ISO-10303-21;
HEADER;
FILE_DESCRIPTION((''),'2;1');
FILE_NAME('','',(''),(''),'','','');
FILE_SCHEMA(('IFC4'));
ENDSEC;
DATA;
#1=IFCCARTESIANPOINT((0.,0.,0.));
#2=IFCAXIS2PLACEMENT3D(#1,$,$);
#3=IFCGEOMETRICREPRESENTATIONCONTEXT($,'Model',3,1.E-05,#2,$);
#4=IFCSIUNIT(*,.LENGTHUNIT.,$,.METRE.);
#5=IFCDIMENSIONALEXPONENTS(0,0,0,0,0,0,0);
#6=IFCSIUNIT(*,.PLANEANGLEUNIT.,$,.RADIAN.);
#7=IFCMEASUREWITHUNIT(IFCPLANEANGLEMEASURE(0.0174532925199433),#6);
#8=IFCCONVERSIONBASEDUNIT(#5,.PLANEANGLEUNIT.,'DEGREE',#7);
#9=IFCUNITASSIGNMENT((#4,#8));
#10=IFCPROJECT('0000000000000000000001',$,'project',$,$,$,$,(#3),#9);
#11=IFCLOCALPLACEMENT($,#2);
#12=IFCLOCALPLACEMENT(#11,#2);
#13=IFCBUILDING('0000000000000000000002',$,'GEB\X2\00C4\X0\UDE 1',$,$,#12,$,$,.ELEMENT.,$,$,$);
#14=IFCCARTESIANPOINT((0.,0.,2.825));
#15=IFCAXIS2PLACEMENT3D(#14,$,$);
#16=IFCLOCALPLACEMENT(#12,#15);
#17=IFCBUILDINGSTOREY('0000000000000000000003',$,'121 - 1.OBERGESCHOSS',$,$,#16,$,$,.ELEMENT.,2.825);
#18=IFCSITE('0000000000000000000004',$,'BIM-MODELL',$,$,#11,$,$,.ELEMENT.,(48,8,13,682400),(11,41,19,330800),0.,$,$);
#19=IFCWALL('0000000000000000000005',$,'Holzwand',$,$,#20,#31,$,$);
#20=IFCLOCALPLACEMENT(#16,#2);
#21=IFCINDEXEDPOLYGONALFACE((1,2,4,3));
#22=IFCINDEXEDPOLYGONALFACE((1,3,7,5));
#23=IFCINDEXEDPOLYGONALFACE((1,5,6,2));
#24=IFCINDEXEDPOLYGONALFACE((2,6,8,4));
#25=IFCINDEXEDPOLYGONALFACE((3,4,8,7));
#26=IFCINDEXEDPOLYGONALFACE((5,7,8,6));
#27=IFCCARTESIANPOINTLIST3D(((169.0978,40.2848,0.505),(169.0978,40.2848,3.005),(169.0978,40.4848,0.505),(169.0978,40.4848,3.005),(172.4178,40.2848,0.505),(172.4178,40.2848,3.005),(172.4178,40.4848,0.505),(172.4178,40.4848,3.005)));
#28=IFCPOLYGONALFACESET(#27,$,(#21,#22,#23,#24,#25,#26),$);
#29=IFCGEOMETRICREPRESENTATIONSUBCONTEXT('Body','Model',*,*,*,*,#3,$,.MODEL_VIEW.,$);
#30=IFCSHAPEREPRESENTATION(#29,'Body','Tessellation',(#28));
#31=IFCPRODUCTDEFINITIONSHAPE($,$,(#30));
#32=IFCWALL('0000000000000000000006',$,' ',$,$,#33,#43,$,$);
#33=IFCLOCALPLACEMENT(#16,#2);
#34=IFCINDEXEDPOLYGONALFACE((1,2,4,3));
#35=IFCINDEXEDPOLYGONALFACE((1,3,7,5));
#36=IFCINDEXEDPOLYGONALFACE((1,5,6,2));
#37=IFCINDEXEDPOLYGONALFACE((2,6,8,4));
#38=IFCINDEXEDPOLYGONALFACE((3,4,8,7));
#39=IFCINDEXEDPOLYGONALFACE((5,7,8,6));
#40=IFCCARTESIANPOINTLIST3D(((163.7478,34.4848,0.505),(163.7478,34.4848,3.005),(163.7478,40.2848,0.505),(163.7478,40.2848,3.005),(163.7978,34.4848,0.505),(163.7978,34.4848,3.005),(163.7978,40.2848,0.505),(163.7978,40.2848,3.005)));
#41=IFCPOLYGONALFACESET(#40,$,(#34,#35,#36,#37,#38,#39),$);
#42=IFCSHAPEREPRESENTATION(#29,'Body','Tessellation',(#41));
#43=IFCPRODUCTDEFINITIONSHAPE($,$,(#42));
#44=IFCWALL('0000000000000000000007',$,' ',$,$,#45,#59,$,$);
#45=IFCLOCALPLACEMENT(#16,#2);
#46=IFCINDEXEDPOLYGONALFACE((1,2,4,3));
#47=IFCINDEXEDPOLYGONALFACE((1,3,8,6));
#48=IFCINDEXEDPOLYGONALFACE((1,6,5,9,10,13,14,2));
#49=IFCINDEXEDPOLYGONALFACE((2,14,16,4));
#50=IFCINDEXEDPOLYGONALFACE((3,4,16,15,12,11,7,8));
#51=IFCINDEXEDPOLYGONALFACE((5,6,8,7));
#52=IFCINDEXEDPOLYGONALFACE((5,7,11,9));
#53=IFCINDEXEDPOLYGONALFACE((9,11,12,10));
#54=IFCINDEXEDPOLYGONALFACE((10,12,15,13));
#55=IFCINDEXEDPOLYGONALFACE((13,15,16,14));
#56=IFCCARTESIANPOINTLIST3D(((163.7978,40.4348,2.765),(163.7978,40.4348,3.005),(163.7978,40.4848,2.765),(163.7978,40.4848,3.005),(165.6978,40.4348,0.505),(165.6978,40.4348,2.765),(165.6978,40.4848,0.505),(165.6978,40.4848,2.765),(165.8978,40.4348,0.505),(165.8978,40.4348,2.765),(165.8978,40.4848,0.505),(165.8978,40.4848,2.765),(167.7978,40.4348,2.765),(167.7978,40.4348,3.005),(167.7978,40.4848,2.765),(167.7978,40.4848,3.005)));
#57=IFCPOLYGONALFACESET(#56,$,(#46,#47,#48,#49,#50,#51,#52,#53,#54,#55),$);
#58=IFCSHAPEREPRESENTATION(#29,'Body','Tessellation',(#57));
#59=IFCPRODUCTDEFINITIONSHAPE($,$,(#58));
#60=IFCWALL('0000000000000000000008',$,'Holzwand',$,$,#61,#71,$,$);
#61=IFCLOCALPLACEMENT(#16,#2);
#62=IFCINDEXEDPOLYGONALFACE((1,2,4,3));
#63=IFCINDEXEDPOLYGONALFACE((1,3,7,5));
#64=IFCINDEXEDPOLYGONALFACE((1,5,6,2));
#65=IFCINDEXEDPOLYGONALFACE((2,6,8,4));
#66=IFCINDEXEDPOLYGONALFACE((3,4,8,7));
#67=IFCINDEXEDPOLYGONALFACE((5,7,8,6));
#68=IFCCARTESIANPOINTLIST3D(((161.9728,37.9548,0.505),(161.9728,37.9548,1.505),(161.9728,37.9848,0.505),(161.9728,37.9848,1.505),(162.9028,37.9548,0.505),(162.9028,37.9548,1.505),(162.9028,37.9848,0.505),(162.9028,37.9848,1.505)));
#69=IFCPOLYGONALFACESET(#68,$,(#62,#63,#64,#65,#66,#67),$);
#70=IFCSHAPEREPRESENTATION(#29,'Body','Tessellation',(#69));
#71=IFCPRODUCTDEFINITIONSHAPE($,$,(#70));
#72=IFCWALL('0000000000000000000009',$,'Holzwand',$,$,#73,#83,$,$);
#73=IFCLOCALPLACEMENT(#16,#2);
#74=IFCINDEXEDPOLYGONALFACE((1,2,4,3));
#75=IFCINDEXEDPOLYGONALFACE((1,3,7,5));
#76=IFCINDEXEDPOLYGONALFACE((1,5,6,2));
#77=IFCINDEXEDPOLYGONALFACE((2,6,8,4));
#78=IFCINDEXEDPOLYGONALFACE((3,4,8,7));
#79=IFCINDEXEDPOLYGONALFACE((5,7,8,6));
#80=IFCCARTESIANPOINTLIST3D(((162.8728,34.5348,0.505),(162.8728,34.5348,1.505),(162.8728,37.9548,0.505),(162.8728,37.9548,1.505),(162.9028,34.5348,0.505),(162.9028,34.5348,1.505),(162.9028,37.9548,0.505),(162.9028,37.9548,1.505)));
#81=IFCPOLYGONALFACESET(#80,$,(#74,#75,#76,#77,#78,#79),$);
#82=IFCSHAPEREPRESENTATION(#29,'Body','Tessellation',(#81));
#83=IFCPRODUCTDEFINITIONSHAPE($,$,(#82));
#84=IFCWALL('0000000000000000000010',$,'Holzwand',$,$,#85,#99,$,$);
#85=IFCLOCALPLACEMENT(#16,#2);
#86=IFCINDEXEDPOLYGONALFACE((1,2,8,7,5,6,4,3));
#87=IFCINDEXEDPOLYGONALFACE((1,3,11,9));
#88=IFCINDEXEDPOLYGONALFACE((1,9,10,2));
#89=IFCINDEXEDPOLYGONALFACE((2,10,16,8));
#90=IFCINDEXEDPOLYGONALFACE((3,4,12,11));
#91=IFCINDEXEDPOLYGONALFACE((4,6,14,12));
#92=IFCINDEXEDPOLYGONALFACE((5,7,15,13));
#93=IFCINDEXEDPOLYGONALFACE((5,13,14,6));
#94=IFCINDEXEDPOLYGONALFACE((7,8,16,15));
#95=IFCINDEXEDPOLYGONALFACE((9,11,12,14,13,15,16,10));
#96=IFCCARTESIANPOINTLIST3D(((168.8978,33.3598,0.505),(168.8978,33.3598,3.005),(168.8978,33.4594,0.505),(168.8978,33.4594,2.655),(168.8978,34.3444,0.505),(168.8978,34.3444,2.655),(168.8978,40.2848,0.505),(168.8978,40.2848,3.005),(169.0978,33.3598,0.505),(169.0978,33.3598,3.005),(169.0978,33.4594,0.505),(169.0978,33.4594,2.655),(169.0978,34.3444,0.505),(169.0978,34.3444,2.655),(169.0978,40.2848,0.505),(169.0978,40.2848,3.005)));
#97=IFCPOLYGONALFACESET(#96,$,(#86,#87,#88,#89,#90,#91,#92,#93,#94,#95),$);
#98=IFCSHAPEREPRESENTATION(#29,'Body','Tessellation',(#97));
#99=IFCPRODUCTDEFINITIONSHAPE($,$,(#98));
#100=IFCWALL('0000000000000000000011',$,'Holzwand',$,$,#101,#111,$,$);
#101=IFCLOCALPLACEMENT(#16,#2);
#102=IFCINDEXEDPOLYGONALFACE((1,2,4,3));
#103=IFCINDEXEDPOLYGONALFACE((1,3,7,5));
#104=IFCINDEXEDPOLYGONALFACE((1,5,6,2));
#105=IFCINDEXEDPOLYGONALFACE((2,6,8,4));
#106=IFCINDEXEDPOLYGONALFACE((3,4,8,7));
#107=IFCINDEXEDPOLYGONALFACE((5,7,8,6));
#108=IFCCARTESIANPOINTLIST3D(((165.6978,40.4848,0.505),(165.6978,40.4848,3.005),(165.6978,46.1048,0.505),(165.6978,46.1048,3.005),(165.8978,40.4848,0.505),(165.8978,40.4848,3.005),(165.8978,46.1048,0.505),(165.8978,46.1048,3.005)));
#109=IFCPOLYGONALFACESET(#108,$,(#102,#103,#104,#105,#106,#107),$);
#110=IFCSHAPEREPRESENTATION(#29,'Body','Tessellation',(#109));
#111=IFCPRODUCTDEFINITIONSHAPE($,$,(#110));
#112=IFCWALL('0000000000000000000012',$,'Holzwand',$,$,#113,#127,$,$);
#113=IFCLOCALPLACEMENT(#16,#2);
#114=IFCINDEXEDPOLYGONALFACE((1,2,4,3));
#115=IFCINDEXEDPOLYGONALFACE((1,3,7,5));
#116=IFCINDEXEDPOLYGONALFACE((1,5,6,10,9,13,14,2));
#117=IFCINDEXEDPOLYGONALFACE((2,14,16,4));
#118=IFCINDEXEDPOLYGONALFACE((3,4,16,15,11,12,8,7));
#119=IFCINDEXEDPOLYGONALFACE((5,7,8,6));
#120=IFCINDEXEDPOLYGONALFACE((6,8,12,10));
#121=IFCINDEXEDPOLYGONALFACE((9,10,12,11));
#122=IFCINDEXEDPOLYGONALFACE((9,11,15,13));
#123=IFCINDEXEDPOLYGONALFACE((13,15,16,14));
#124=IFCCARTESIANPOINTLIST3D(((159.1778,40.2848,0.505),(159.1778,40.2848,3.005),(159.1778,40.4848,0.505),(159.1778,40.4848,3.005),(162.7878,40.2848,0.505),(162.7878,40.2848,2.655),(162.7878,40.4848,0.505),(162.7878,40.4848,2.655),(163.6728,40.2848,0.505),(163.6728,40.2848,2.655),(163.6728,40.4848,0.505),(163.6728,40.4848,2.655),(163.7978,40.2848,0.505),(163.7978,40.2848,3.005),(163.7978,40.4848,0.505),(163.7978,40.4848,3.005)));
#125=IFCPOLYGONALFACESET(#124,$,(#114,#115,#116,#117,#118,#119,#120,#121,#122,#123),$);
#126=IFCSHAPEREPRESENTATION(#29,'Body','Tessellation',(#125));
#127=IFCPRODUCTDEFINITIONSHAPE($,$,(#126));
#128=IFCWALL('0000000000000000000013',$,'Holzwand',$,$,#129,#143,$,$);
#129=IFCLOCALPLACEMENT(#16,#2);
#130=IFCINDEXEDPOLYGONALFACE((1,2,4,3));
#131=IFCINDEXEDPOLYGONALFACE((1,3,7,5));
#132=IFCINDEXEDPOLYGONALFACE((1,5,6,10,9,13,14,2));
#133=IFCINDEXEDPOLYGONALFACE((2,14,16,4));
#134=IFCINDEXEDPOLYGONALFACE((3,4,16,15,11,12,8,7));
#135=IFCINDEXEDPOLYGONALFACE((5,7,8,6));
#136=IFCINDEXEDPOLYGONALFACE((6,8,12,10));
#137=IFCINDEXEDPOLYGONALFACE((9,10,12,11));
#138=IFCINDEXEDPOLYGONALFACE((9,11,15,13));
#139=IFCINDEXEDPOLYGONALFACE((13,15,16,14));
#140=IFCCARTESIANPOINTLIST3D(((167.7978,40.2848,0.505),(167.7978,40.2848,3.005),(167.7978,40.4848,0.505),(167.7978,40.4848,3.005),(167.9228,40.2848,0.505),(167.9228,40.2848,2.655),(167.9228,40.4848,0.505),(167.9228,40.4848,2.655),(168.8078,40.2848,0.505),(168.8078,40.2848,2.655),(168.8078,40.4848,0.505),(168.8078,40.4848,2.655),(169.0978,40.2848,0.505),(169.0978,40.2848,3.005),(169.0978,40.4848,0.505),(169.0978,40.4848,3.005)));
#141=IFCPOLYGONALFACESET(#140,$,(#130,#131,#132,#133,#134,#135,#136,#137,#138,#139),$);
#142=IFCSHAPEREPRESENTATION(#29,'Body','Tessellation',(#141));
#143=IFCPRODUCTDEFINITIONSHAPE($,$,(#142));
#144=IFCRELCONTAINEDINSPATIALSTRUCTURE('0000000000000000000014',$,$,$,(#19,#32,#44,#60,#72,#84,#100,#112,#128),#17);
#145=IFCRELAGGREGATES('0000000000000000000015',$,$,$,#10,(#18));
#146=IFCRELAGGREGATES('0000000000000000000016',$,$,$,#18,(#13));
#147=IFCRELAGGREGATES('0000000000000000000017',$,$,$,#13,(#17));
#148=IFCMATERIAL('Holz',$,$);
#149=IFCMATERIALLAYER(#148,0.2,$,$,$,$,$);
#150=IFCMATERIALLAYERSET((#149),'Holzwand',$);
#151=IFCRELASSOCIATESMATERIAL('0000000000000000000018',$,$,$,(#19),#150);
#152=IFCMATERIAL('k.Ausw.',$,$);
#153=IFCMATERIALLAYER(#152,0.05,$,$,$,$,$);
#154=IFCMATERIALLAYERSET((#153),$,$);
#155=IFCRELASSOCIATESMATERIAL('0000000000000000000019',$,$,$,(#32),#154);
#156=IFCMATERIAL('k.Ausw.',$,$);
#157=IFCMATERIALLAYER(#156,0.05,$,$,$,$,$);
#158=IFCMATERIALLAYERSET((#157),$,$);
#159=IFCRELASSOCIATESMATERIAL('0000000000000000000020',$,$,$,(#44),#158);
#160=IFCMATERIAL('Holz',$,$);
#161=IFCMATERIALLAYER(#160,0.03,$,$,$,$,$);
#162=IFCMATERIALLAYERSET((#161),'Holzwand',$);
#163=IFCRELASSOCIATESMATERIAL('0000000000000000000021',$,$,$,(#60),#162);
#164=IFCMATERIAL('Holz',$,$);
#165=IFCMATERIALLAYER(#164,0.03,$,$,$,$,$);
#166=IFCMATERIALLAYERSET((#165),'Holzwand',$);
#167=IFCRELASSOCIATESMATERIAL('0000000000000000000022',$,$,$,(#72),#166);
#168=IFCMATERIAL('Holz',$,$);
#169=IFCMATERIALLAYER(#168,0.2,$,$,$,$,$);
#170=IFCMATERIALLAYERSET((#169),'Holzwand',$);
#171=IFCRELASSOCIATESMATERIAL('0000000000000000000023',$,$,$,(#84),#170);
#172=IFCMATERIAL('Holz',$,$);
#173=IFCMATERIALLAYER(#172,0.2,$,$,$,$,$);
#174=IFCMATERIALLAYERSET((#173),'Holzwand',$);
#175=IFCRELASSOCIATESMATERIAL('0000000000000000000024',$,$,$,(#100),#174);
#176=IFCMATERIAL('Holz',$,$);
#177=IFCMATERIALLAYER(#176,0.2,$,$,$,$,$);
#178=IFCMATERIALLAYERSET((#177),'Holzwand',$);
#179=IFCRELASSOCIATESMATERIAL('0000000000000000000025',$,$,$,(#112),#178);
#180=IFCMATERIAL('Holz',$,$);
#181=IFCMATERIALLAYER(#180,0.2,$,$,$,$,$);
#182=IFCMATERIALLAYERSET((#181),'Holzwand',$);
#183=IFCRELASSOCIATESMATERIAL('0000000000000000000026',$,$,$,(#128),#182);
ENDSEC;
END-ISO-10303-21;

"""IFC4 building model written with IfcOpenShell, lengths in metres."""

from ifc_helpers import new_model, entity, si_unit, converted_unit, frame, frame_2d, origin, origin_with_axes, place, context, subcontext, project, spatial, polyline, rectangle, outline, extrude, material, layer, layer_set, layer_usage, element, save


model = new_model("IFC4")

# Units and contexts
model_context = context("Model", 3, precision=1e-05, world=origin())
body_context = subcontext(model_context, "Body", "Model", "MODEL_VIEW")
ifc_project = project(units=[si_unit("LENGTHUNIT", "METRE"), converted_unit("PLANEANGLEUNIT", "DEGREE", entity("IfcPlaneAngleMeasure", 0.0174532925199433), si_unit("PLANEANGLEUNIT", "RADIAN"), dimensions=[0, 0, 0, 0, 0, 0, 0])], contexts=[model_context])

# Site, building, storey
site_placement = place(None, origin())
site = spatial("IfcSite", under=ifc_project, at=site_placement, Name="BIM-MODELL", CompositionType="ELEMENT", RefLatitude=(48, 8, 13, 682400), RefLongitude=(11, 41, 19, 330800), RefElevation=0.0)
building_placement = place(site_placement, origin())
building = spatial("IfcBuilding", under=site, at=building_placement, Name="GEBÄUDE 1", CompositionType="ELEMENT")
storey_placement = place(building_placement, frame((0.0, 0.0, 2.825)))
storey = spatial("IfcBuildingStorey", under=building, at=storey_placement, Name="121 - 1.OBERGESCHOSS", CompositionType="ELEMENT", Elevation=2.825)

# Walls
ifc_material_1 = material(Name="Holz")
ifc_layer_1 = layer(ifc_material_1, 0.2)
ifc_layer_set_1 = layer_set([ifc_layer_1], Name="Holzwand")
ifc_layer_usage_1 = layer_usage(ifc_layer_set_1, "AXIS2", "POSITIVE", -0.1)
wall_1_placement = place(storey_placement, frame((172.4178, 40.4848, 0.505), z_axis=(0.0, 0.0, 1.0), x_axis=(-1.0, 0.0, 0.0)))
element("IfcWall", 1, at=wall_1_placement, inside=storey, material=ifc_layer_usage_1, Name="Holzwand", context=body_context, shape_type="SweptSolid", body=[
    extrude(rectangle(XDim=3.32, YDim=0.2, at=frame_2d((1.66, 0.1), x_axis=(1.0, 0.0))), origin_with_axes(), (0.0, 0.0, 1.0), 2.5),
])
ifc_material_2 = material(Name="k.Ausw.")
ifc_layer_2 = layer(ifc_material_2, 0.05)
ifc_layer_set_2 = layer_set([ifc_layer_2])
ifc_layer_usage_2 = layer_usage(ifc_layer_set_2, "AXIS2", "POSITIVE", 0.0)
wall_2_placement = place(storey_placement, frame((163.7478, 40.2848, 0.505), z_axis=(0.0, 0.0, 1.0), x_axis=(0.0, -1.0, 0.0)))
element("IfcWall", 2, at=wall_2_placement, inside=storey, material=ifc_layer_usage_2, Name=" ", context=body_context, shape_type="SweptSolid", body=[
    extrude(rectangle(XDim=5.8, YDim=0.05, at=frame_2d((2.9, 0.025), x_axis=(1.0, 0.0))), origin_with_axes(), (0.0, 0.0, 1.0), 2.5),
])

# Wall, openings
ifc_material_3 = material(Name="k.Ausw.")
ifc_layer_3 = layer(ifc_material_3, 0.05)
ifc_layer_set_3 = layer_set([ifc_layer_3])
ifc_layer_usage_3 = layer_usage(ifc_layer_set_3, "AXIS2", "POSITIVE", 0.0)
wall_3_placement = place(storey_placement, frame((167.7978, 40.4848, 0.505), z_axis=(0.0, 0.0, 1.0), x_axis=(-1.0, 0.0, 0.0)))
wall_3 = element("IfcWall", 3, at=wall_3_placement, inside=storey, material=ifc_layer_usage_3, Name=" ", context=body_context, shape_type="SweptSolid", body=[
    extrude(rectangle(XDim=4.0, YDim=0.05, at=frame_2d((2.0, 0.025), x_axis=(1.0, 0.0))), origin_with_axes(), (0.0, 0.0, 1.0), 2.5),
])
opening_1_placement = place(wall_3_placement, frame((2.1, 0.0, 0.0), z_axis=(0.0, 1.0, 0.0), x_axis=(0.0, 0.0, 1.0)))
element("IfcOpeningElement", 4, at=opening_1_placement, cuts=wall_3, ObjectType="Opening", context=body_context, shape_type="SweptSolid", body=[
    extrude(outline(polyline([(0.0, 1.9), (2.26, 1.9), (2.26, 0.0), (0.0, 0.0), (0.0, 1.9)])), origin_with_axes(), (0.0, 0.0, 1.0), 0.05),
])
opening_2_placement = place(wall_3_placement, frame((0.0, 0.0, 0.0), z_axis=(0.0, 1.0, 0.0), x_axis=(0.0, 0.0, 1.0)))
element("IfcOpeningElement", 5, at=opening_2_placement, cuts=wall_3, ObjectType="Opening", context=body_context, shape_type="SweptSolid", body=[
    extrude(outline(polyline([(0.0, 1.9), (2.26, 1.9), (2.26, 0.0), (0.0, 0.0), (0.0, 1.9)])), origin_with_axes(), (0.0, 0.0, 1.0), 0.05),
])
opening_3_placement = place(wall_3_placement, frame((0.0, 0.0, 0.0), z_axis=(0.0, 1.0, 0.0), x_axis=(0.0, 0.0, 1.0)))
element("IfcOpeningElement", 6, at=opening_3_placement, cuts=wall_3, ObjectType="Opening", context=body_context, shape_type="SweptSolid", body=[
    extrude(outline(polyline([(0.0, 1.9), (2.26, 1.9), (2.26, 0.0), (0.0, 0.0), (0.0, 1.9)])), origin_with_axes(), (0.0, 0.0, 1.0), 0.05),
])

# Walls
ifc_material_4 = material(Name="Holz")
ifc_layer_4 = layer(ifc_material_4, 0.03)
ifc_layer_set_4 = layer_set([ifc_layer_4], Name="Holzwand")
ifc_layer_usage_4 = layer_usage(ifc_layer_set_4, "AXIS2", "POSITIVE", 0.0)
wall_4_placement = place(storey_placement, frame((161.9728, 37.9548, 0.505), z_axis=(0.0, 0.0, 1.0), x_axis=(1.0, 0.0, 0.0)))
element("IfcWall", 7, at=wall_4_placement, inside=storey, material=ifc_layer_usage_4, Name="Holzwand", context=body_context, shape_type="SweptSolid", body=[
    extrude(rectangle(XDim=0.93, YDim=0.03, at=frame_2d((0.465, 0.015), x_axis=(1.0, 0.0))), origin_with_axes(), (0.0, 0.0, 1.0), 1.0),
])
ifc_material_5 = material(Name="Holz")
ifc_layer_5 = layer(ifc_material_5, 0.03)
ifc_layer_set_5 = layer_set([ifc_layer_5], Name="Holzwand")
ifc_layer_usage_5 = layer_usage(ifc_layer_set_5, "AXIS2", "POSITIVE", 0.0)
wall_5_placement = place(storey_placement, frame((162.8728, 37.9548, 0.505), z_axis=(0.0, 0.0, 1.0), x_axis=(0.0, -1.0, 0.0)))
element("IfcWall", 8, at=wall_5_placement, inside=storey, material=ifc_layer_usage_5, Name="Holzwand", context=body_context, shape_type="SweptSolid", body=[
    extrude(rectangle(XDim=3.42, YDim=0.03, at=frame_2d((1.71, 0.015), x_axis=(1.0, 0.0))), origin_with_axes(), (0.0, 0.0, 1.0), 1.0),
])

# Wall, opening
ifc_material_6 = material(Name="Holz")
ifc_layer_6 = layer(ifc_material_6, 0.2)
ifc_layer_set_6 = layer_set([ifc_layer_6], Name="Holzwand")
ifc_layer_usage_6 = layer_usage(ifc_layer_set_6, "AXIS2", "POSITIVE", 0.0)
wall_6_placement = place(storey_placement, frame((168.8978, 40.2848, 0.505), z_axis=(0.0, 0.0, 1.0), x_axis=(0.0, -1.0, 0.0)))
wall_6 = element("IfcWall", 9, at=wall_6_placement, inside=storey, material=ifc_layer_usage_6, Name="Holzwand", context=body_context, shape_type="SweptSolid", body=[
    extrude(rectangle(XDim=6.925, YDim=0.2, at=frame_2d((3.4625, 0.1), x_axis=(1.0, 0.0))), origin_with_axes(), (0.0, 0.0, 1.0), 2.5),
])
opening_4_placement = place(wall_6_placement, frame((5.9404, 0.0, -0.15), z_axis=(0.0, 1.0, 0.0), x_axis=(0.0, 0.0, 1.0)))
element("IfcOpeningElement", 10, at=opening_4_placement, cuts=wall_6, ObjectType="Opening", context=body_context, shape_type="SweptSolid", body=[
    extrude(outline(polyline([(0.0, 0.885), (2.3, 0.885), (2.3, 0.0), (0.0, 0.0), (0.0, 0.885)])), origin_with_axes(), (0.0, 0.0, 1.0), 0.2),
])

# Wall
ifc_material_7 = material(Name="Holz")
ifc_layer_7 = layer(ifc_material_7, 0.2)
ifc_layer_set_7 = layer_set([ifc_layer_7], Name="Holzwand")
ifc_layer_usage_7 = layer_usage(ifc_layer_set_7, "AXIS2", "POSITIVE", 0.0)
wall_7_placement = place(storey_placement, frame((165.6978, 46.1048, 0.505), z_axis=(0.0, 0.0, 1.0), x_axis=(0.0, -1.0, 0.0)))
element("IfcWall", 11, at=wall_7_placement, inside=storey, material=ifc_layer_usage_7, Name="Holzwand", context=body_context, shape_type="SweptSolid", body=[
    extrude(rectangle(XDim=5.62, YDim=0.2, at=frame_2d((2.81, 0.1), x_axis=(1.0, 0.0))), origin_with_axes(), (0.0, 0.0, 1.0), 2.5),
])

# Walls, openings
ifc_material_8 = material(Name="Holz")
ifc_layer_8 = layer(ifc_material_8, 0.2)
ifc_layer_set_8 = layer_set([ifc_layer_8], Name="Holzwand")
ifc_layer_usage_8 = layer_usage(ifc_layer_set_8, "AXIS2", "POSITIVE", 0.0)
wall_8_placement = place(storey_placement, frame((163.7978, 40.4848, 0.505), z_axis=(0.0, 0.0, 1.0), x_axis=(-1.0, 0.0, 0.0)))
wall_8 = element("IfcWall", 12, at=wall_8_placement, inside=storey, material=ifc_layer_usage_8, Name="Holzwand", context=body_context, shape_type="SweptSolid", body=[
    extrude(rectangle(XDim=4.62, YDim=0.2, at=frame_2d((2.31, 0.1), x_axis=(1.0, 0.0))), origin_with_axes(), (0.0, 0.0, 1.0), 2.5),
])
opening_5_placement = place(wall_8_placement, frame((1.01, 0.2, -0.15), z_axis=(0.0, -1.0, 0.0), x_axis=(0.0, 0.0, 1.0)))
element("IfcOpeningElement", 13, at=opening_5_placement, cuts=wall_8, ObjectType="Opening", context=body_context, shape_type="SweptSolid", body=[
    extrude(outline(polyline([(0.0, 0.885), (2.3, 0.885), (2.3, 0.0), (0.0, 0.0), (0.0, 0.885)])), origin_with_axes(), (0.0, 0.0, 1.0), 0.2),
])
ifc_material_9 = material(Name="Holz")
ifc_layer_9 = layer(ifc_material_9, 0.2)
ifc_layer_set_9 = layer_set([ifc_layer_9], Name="Holzwand")
ifc_layer_usage_9 = layer_usage(ifc_layer_set_9, "AXIS2", "POSITIVE", 0.0)
wall_9_placement = place(storey_placement, frame((169.0978, 40.4848, 0.505), z_axis=(0.0, 0.0, 1.0), x_axis=(-1.0, 0.0, 0.0)))
wall_9 = element("IfcWall", 14, at=wall_9_placement, inside=storey, material=ifc_layer_usage_9, Name="Holzwand", context=body_context, shape_type="SweptSolid", body=[
    extrude(rectangle(XDim=1.3, YDim=0.2, at=frame_2d((0.65, 0.1), x_axis=(1.0, 0.0))), origin_with_axes(), (0.0, 0.0, 1.0), 2.5),
])
opening_6_placement = place(wall_9_placement, frame((1.175, 0.2, -0.15), z_axis=(0.0, -1.0, 0.0), x_axis=(0.0, 0.0, 1.0)))
element("IfcOpeningElement", 15, at=opening_6_placement, cuts=wall_9, ObjectType="Opening", context=body_context, shape_type="SweptSolid", body=[
    extrude(outline(polyline([(0.0, 0.885), (2.3, 0.885), (2.3, 0.0), (0.0, 0.0), (0.0, 0.885)])), origin_with_axes(), (0.0, 0.0, 1.0), 0.2),
])

save(model, "model.ifc")
